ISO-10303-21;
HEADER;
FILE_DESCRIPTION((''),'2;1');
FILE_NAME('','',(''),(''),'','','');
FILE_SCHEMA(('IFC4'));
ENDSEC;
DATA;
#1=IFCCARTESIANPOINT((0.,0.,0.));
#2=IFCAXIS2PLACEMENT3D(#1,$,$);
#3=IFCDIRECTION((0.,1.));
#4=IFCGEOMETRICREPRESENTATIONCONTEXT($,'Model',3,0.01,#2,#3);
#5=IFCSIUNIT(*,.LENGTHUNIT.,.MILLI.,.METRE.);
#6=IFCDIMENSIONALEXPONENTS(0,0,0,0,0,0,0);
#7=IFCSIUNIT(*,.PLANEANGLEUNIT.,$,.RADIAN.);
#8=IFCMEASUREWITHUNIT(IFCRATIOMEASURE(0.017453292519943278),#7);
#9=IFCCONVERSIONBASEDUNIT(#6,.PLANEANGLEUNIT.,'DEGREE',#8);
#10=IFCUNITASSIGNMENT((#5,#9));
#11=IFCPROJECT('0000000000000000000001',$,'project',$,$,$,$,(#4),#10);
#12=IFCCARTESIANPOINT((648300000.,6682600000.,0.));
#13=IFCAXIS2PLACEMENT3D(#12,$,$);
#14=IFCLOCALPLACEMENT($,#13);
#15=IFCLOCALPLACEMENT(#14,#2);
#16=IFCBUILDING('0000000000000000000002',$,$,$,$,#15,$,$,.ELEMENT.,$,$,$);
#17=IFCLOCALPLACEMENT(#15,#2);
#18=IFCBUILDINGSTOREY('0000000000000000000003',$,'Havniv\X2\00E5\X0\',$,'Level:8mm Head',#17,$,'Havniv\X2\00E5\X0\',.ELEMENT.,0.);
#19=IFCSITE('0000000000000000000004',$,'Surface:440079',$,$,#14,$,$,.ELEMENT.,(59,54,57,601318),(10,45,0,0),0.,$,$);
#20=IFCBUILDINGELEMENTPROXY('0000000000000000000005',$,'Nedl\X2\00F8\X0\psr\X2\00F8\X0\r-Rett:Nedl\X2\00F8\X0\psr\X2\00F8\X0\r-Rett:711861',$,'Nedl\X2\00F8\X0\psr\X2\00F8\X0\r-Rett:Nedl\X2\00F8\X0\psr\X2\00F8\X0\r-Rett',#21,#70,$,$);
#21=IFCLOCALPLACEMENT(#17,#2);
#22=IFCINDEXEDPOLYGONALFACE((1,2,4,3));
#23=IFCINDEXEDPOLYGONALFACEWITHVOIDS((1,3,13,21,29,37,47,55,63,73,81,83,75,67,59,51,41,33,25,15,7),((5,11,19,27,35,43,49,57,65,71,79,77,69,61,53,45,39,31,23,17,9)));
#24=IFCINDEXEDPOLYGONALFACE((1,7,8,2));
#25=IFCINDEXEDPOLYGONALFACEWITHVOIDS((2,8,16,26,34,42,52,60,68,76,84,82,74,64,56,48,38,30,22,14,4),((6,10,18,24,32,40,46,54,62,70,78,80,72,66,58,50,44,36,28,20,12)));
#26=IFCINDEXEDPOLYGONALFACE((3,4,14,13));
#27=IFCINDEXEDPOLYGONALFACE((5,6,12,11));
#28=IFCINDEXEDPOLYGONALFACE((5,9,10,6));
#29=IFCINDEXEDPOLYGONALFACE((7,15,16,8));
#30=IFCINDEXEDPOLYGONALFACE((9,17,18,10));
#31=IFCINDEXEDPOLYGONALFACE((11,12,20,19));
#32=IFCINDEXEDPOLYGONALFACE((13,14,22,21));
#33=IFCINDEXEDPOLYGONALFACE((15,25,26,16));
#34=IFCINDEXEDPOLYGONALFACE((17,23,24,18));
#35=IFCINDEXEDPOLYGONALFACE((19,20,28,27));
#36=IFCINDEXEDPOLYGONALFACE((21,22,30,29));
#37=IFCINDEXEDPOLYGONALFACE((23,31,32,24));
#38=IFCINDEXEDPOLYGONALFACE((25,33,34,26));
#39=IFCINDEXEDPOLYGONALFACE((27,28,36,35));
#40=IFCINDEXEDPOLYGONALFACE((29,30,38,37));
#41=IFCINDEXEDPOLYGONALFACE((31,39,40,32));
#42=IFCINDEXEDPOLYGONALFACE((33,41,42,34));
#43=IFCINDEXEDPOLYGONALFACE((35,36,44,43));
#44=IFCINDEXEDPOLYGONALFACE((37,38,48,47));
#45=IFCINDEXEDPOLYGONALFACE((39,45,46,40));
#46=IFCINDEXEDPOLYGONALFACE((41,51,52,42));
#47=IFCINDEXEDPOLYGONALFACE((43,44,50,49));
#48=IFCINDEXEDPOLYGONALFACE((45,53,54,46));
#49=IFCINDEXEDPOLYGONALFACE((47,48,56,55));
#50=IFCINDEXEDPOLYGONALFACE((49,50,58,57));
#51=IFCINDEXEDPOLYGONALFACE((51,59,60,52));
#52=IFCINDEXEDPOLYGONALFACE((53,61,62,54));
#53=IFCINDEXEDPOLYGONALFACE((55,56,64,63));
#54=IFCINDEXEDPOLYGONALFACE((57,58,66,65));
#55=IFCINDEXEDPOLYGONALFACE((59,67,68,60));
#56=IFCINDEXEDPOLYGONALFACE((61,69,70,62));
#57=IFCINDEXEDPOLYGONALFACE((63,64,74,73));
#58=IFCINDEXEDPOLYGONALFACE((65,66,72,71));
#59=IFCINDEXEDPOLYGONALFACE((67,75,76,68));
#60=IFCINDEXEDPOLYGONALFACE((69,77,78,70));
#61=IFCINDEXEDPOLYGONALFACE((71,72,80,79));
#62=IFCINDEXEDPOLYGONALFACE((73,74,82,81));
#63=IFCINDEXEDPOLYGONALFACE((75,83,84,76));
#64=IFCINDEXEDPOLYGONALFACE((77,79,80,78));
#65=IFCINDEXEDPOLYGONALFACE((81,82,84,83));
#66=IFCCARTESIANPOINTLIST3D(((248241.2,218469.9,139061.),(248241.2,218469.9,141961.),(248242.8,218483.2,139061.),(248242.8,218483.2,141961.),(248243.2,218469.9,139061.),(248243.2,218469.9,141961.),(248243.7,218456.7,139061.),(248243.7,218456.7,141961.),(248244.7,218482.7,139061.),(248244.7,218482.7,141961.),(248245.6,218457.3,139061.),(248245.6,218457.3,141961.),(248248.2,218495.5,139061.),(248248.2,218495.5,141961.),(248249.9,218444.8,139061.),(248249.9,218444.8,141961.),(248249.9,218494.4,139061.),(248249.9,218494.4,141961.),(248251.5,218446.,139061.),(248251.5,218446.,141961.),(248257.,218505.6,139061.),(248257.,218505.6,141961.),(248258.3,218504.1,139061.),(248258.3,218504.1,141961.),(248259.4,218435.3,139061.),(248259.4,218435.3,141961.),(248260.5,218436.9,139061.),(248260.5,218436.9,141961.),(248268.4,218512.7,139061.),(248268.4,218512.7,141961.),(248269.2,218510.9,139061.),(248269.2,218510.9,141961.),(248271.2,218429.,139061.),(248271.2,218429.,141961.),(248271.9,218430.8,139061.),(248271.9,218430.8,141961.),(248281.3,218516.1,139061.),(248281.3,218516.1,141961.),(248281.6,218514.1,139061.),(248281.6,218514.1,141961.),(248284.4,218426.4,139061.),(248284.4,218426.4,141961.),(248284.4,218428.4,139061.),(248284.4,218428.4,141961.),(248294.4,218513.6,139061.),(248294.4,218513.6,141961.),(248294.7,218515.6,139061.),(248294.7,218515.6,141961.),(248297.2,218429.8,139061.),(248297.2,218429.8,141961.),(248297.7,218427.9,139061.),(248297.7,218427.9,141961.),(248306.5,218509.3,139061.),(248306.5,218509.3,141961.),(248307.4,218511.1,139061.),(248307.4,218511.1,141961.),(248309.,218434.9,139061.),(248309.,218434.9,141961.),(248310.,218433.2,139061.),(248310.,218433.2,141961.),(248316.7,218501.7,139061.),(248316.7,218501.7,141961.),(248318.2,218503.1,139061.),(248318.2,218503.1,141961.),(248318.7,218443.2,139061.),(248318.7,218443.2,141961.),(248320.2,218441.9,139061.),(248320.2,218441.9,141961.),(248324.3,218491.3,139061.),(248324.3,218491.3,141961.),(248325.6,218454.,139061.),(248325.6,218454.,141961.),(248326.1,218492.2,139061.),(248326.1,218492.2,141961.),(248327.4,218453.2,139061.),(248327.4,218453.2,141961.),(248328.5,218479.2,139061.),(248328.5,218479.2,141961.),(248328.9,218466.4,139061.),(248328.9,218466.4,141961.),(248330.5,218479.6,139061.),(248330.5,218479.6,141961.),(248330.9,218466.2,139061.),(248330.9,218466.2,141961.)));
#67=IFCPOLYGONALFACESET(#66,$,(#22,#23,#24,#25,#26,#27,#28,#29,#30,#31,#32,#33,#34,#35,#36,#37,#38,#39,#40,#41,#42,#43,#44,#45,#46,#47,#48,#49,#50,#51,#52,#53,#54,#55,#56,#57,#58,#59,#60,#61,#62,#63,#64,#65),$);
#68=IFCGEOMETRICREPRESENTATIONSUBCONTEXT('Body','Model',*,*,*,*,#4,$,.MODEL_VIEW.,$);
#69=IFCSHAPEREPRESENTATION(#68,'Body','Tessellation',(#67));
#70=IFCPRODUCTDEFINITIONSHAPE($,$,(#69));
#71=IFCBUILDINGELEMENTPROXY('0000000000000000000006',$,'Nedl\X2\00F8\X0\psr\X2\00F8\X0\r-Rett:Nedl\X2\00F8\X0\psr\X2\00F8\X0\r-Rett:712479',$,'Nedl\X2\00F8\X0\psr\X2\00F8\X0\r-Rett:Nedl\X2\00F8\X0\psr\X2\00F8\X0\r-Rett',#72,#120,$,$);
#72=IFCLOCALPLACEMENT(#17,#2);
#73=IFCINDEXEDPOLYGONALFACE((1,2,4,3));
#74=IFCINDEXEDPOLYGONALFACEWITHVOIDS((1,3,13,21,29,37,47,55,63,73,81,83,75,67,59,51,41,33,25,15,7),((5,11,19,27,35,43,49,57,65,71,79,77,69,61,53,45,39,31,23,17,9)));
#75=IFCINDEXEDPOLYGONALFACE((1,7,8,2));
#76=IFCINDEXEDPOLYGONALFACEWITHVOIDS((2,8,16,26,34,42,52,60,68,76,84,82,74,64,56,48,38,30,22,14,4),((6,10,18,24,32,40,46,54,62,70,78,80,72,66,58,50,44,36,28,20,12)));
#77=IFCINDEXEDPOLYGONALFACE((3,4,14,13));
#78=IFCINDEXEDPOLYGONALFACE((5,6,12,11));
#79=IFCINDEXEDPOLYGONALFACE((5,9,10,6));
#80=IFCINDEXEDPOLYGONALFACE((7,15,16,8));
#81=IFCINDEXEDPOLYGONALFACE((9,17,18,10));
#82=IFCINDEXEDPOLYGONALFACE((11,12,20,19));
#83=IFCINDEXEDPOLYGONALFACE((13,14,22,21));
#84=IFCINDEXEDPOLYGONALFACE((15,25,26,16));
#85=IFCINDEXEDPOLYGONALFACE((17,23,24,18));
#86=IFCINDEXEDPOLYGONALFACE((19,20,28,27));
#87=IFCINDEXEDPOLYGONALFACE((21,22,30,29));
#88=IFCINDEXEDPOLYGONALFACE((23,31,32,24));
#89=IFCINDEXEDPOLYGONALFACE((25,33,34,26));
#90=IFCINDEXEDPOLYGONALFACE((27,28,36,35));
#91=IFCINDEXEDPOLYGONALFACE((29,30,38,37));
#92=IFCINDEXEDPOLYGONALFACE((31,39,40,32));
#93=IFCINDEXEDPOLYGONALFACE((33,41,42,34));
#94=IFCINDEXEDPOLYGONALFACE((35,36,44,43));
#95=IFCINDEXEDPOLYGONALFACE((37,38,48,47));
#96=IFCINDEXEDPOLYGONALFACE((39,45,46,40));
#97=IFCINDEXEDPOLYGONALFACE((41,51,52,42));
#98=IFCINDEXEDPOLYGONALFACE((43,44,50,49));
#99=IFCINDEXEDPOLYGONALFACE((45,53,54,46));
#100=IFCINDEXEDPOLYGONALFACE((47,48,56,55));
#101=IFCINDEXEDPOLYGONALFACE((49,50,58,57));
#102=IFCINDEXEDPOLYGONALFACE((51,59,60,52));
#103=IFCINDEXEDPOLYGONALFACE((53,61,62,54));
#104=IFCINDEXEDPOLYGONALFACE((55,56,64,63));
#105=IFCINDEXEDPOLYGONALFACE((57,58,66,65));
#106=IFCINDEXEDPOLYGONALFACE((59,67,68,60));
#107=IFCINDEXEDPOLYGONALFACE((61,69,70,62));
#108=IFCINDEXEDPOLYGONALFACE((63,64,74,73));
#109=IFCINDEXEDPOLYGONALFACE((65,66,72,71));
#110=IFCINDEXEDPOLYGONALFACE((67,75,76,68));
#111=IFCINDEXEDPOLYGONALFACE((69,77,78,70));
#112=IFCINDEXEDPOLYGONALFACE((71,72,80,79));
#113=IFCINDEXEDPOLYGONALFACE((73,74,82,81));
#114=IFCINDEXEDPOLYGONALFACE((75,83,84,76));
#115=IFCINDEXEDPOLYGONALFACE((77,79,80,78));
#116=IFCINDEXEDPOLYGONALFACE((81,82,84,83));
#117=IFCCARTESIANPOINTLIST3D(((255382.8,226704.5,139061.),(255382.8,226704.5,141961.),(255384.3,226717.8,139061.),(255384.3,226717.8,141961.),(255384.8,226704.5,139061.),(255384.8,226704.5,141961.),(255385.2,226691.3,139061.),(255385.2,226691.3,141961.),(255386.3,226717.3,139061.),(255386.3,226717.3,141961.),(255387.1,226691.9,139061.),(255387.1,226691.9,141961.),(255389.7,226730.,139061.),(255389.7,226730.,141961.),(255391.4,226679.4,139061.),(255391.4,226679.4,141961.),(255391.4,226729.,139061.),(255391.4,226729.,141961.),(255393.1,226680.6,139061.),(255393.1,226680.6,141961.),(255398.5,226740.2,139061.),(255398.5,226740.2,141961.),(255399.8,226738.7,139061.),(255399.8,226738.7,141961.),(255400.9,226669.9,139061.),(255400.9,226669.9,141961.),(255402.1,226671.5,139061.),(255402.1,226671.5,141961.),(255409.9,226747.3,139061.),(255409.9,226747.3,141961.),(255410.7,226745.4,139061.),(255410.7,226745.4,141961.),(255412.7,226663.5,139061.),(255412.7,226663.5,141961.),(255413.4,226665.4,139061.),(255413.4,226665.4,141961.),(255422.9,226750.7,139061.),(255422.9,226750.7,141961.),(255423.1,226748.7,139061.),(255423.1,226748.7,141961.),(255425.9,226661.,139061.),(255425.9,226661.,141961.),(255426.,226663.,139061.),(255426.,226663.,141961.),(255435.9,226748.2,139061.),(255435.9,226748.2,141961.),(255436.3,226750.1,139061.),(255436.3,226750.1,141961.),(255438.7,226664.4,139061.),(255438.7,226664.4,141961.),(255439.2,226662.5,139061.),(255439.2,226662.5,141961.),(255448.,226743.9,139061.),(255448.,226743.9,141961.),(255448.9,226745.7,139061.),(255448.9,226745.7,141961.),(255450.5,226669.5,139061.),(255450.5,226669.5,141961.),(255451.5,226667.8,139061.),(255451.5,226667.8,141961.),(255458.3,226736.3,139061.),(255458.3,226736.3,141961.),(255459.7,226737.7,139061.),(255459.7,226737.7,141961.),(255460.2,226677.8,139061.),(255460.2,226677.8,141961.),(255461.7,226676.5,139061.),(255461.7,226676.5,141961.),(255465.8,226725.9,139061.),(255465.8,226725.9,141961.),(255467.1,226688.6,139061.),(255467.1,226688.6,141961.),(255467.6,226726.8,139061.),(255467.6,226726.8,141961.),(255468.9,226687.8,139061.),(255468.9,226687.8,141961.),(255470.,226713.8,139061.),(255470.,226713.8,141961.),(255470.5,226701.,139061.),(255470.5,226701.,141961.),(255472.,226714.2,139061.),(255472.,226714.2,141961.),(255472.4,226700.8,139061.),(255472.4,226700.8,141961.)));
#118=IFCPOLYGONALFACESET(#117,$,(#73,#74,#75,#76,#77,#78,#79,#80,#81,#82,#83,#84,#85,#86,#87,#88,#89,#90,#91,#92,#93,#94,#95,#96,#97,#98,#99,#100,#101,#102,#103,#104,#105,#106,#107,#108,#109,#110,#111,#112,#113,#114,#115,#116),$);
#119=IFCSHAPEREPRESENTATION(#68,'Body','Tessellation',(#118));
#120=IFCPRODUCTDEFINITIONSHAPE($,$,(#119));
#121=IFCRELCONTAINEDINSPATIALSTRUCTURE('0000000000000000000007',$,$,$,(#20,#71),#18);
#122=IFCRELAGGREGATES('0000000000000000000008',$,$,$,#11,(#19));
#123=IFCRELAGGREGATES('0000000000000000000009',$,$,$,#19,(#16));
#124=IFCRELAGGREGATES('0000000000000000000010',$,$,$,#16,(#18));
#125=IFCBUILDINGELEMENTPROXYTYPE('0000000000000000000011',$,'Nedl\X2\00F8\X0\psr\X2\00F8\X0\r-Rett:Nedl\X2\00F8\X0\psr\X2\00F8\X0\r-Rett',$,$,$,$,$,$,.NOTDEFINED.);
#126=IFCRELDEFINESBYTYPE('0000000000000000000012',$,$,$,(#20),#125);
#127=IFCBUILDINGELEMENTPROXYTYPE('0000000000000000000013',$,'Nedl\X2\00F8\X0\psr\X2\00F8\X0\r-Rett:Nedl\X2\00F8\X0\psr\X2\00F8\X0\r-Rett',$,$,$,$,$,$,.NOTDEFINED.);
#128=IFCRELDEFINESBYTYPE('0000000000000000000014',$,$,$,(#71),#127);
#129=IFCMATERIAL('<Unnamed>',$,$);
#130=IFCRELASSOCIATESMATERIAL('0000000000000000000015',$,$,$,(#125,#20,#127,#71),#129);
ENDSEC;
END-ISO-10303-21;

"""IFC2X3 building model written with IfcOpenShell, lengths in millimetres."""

from ifc_helpers import new_model, entity, si_unit, converted_unit, direction, frame, frame_2d, origin, place, context, subcontext, project, spatial, hollow_circle, extrude, source, transform, mapped, material, type_object, type_shapes, element, save


model = new_model("IFC2X3")

# Units and contexts
model_context = context("Model", 3, precision=0.01, world=origin(), true_north=direction((0.0, 1.0)))
body_context = subcontext(model_context, "Body", "Model", "MODEL_VIEW")
ifc_project = project(units=[si_unit("LENGTHUNIT", "METRE", prefix="MILLI"), converted_unit("PLANEANGLEUNIT", "DEGREE", entity("IfcRatioMeasure", 0.017453292519943278), si_unit("PLANEANGLEUNIT", "RADIAN"), dimensions=[0, 0, 0, 0, 0, 0, 0])], contexts=[model_context])

# Site, building, storey
site_placement = place(None, frame((648300000.0, 6682600000.0, 0.0)))
site = spatial("IfcSite", under=ifc_project, at=site_placement, Name="Surface:440079", CompositionType="ELEMENT", RefLatitude=(59, 54, 57, 601318), RefLongitude=(10, 45, 0, 0), RefElevation=0.0)
building_placement = place(site_placement, origin())
building = spatial("IfcBuilding", under=site, at=building_placement, CompositionType="ELEMENT")
storey_placement = place(building_placement, origin())
storey = spatial("IfcBuildingStorey", under=building, at=storey_placement, Name="Havnivå", ObjectType="Level:8mm Head", LongName="Havnivå", CompositionType="ELEMENT", Elevation=0.0)

# Building element proxies
ifc_material_1 = material(Name="<Unnamed>")
building_element_proxy_type_1 = type_object("IfcBuildingElementProxyType", Name="Nedløpsrør-Rett:Nedløpsrør-Rett", PredefinedType="NOTDEFINED", material=ifc_material_1)
shared_shape_1 = source(origin(), body_context, "Body", "SweptSolid", [
    extrude(hollow_circle(Radius=45.0, WallThickness=2.0, at=frame_2d((0.0, 0.0), x_axis=(1.0, 0.0))), frame((0.0, 0.0, 0.0), z_axis=(0.0, 0.0, 1.0), x_axis=(-1.0, 0.0, 0.0)), (0.0, 0.0, 1.0), 2900.0),
])
type_shapes(building_element_proxy_type_1, [shared_shape_1])
proxy_1_placement = place(storey_placement, frame((248286.2, 218471.4, 139061.0), z_axis=(0.0, 0.0, 1.0), x_axis=(-0.755467, 0.655187, 0.0)))
element("IfcBuildingElementProxy", 1, at=proxy_1_placement, inside=storey, type_object=building_element_proxy_type_1, material=ifc_material_1, Name="Nedløpsrør-Rett:Nedløpsrør-Rett:711861", ObjectType="Nedløpsrør-Rett:Nedløpsrør-Rett", context=body_context, shape_type="MappedRepresentation", body=[
    mapped(shared_shape_1, transform((0.0, 0.0, 0.0), scale=1.0)),
])
building_element_proxy_type_2 = type_object("IfcBuildingElementProxyType", Name="Nedløpsrør-Rett:Nedløpsrør-Rett", PredefinedType="NOTDEFINED", material=ifc_material_1)
shared_shape_2 = source(origin(), body_context, "Body", "SweptSolid", [
    extrude(hollow_circle(Radius=45.0, WallThickness=2.0, at=frame_2d((0.0, 0.0), x_axis=(1.0, 0.0))), frame((0.0, 0.0, 0.0), z_axis=(0.0, 0.0, 1.0), x_axis=(-1.0, 0.0, 0.0)), (0.0, 0.0, 1.0), 2900.0),
])
type_shapes(building_element_proxy_type_2, [shared_shape_2])
proxy_2_placement = place(storey_placement, frame((255427.8, 226706.0, 139061.0), z_axis=(0.0, 0.0, 1.0), x_axis=(-0.755467, 0.655187, 0.0)))
element("IfcBuildingElementProxy", 2, at=proxy_2_placement, inside=storey, type_object=building_element_proxy_type_2, material=ifc_material_1, Name="Nedløpsrør-Rett:Nedløpsrør-Rett:712479", ObjectType="Nedløpsrør-Rett:Nedløpsrør-Rett", context=body_context, shape_type="MappedRepresentation", body=[
    mapped(shared_shape_2, transform((0.0, 0.0, 0.0), scale=1.0)),
])

save(model, "model.ifc")
